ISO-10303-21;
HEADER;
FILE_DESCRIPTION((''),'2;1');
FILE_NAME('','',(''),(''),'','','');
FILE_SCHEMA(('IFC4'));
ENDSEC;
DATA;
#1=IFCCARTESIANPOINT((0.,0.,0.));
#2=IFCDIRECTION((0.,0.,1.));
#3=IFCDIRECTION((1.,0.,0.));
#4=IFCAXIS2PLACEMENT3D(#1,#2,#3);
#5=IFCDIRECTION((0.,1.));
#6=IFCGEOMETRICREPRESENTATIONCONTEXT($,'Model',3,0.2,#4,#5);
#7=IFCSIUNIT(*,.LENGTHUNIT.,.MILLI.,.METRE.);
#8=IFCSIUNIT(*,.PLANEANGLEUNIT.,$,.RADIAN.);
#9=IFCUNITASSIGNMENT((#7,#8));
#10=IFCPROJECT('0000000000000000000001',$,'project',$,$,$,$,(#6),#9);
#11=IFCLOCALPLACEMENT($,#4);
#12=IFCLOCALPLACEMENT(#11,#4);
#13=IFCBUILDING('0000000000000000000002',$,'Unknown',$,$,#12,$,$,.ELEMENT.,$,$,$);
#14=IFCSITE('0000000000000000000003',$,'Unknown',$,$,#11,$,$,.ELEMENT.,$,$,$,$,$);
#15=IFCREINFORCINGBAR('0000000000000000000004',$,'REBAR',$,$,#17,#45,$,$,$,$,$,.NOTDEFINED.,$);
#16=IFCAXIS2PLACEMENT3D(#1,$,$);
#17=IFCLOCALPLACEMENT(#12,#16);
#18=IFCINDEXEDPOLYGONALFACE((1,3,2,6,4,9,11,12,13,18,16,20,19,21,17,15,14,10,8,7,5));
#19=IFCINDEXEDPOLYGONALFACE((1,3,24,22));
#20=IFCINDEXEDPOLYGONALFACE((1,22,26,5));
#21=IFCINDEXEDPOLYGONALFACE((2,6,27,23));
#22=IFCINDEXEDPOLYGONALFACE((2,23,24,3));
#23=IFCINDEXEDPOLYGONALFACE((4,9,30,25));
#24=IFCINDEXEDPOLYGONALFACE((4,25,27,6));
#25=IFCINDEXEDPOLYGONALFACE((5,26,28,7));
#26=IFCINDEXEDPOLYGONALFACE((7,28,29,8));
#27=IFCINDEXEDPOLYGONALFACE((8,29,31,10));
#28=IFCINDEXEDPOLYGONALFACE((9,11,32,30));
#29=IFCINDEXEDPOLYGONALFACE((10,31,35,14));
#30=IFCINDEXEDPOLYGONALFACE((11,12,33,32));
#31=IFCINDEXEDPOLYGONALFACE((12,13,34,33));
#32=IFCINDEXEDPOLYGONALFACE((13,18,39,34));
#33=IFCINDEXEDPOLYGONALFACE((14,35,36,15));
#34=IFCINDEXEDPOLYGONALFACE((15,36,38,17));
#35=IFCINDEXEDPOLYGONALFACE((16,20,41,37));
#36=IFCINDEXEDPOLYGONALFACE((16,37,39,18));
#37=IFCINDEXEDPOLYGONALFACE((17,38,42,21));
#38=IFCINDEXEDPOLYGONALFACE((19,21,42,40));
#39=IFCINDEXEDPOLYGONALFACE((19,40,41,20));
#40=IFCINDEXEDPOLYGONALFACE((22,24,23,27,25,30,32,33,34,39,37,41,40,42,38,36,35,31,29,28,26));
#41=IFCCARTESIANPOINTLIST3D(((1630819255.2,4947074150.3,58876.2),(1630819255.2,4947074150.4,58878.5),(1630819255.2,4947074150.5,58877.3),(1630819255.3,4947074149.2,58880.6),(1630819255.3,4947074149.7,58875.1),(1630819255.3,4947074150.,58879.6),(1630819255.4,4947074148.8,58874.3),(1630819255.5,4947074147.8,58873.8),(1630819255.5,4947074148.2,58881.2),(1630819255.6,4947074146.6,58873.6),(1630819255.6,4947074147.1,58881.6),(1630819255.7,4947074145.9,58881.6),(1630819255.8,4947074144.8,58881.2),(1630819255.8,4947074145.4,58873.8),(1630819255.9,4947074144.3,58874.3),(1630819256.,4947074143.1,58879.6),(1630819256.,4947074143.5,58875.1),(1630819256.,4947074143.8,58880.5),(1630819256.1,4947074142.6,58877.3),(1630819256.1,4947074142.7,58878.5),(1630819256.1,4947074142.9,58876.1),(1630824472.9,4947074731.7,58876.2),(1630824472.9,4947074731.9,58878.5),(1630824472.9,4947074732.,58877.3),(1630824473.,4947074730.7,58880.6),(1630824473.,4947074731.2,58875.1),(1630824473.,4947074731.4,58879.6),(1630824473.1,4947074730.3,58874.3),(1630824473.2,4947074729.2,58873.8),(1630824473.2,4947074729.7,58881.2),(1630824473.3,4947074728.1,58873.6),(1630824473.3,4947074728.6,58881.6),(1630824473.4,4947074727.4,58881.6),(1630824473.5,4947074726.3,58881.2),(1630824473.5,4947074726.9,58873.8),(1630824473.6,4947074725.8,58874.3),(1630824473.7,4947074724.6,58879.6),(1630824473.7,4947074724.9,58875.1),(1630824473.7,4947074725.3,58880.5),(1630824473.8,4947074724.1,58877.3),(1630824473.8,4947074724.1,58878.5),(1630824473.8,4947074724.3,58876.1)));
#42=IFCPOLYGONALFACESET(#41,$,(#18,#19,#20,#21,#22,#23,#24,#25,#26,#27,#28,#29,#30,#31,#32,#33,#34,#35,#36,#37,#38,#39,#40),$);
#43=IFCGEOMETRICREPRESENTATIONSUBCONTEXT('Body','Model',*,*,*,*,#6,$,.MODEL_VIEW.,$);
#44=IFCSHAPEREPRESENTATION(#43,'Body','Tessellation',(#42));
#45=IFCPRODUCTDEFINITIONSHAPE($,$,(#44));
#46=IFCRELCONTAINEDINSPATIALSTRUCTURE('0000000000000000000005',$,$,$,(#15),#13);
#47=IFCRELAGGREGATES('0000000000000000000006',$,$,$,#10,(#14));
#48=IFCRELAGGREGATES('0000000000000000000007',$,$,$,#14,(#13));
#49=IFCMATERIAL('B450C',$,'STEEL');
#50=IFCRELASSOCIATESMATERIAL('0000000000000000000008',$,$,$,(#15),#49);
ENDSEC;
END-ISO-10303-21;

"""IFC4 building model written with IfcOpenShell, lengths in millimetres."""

from ifc_helpers import new_model, entity, si_unit, direction, frame, origin_with_axes, place, context, subcontext, project, spatial, material, element, save


model = new_model("IFC4")

# Units and contexts
model_context = context("Model", 3, precision=0.2, world=origin_with_axes(), true_north=direction((0.0, 1.0)))
body_context = subcontext(model_context, "Body", "Model", "MODEL_VIEW")
ifc_project = project(units=[si_unit("LENGTHUNIT", "METRE", prefix="MILLI"), si_unit("PLANEANGLEUNIT", "RADIAN")], contexts=[model_context])

# Site, building
site_placement = place(None, origin_with_axes())
site = spatial("IfcSite", under=ifc_project, at=site_placement, Name="Unknown", CompositionType="ELEMENT")
building_placement = place(site_placement, origin_with_axes())
building = spatial("IfcBuilding", under=site, at=building_placement, Name="Unknown", CompositionType="ELEMENT")

# Reinforcing bar
ifc_material = material(Name="B450C", Category="STEEL")
for number, where, z_axis, x_axis, name in (
    (1, (1630819255.6, 4947074146.5, 58877.6), (-0.007106, 0.063762, 0.99794), (0.993847, 0.110757, 0.0), "REBAR"),
):
    element("IfcReinforcingBar", number, at=place(building_placement, frame(where, z_axis=z_axis, x_axis=x_axis)), inside=building, material=ifc_material, Name=name, PredefinedType="NOTDEFINED", context=body_context, shape_type="AdvancedSweptSolid", body=[
        entity("IfcSweptDiskSolid", entity("IfcIndexedPolyCurve", entity("IfcCartesianPointList3D", [[0.0, 0.0, 0.0], [5250.0, 0.0, 0.0]]), [entity("IfcLineIndex", [1, 2])]), 4.0),
    ])

save(model, "model.ifc")
